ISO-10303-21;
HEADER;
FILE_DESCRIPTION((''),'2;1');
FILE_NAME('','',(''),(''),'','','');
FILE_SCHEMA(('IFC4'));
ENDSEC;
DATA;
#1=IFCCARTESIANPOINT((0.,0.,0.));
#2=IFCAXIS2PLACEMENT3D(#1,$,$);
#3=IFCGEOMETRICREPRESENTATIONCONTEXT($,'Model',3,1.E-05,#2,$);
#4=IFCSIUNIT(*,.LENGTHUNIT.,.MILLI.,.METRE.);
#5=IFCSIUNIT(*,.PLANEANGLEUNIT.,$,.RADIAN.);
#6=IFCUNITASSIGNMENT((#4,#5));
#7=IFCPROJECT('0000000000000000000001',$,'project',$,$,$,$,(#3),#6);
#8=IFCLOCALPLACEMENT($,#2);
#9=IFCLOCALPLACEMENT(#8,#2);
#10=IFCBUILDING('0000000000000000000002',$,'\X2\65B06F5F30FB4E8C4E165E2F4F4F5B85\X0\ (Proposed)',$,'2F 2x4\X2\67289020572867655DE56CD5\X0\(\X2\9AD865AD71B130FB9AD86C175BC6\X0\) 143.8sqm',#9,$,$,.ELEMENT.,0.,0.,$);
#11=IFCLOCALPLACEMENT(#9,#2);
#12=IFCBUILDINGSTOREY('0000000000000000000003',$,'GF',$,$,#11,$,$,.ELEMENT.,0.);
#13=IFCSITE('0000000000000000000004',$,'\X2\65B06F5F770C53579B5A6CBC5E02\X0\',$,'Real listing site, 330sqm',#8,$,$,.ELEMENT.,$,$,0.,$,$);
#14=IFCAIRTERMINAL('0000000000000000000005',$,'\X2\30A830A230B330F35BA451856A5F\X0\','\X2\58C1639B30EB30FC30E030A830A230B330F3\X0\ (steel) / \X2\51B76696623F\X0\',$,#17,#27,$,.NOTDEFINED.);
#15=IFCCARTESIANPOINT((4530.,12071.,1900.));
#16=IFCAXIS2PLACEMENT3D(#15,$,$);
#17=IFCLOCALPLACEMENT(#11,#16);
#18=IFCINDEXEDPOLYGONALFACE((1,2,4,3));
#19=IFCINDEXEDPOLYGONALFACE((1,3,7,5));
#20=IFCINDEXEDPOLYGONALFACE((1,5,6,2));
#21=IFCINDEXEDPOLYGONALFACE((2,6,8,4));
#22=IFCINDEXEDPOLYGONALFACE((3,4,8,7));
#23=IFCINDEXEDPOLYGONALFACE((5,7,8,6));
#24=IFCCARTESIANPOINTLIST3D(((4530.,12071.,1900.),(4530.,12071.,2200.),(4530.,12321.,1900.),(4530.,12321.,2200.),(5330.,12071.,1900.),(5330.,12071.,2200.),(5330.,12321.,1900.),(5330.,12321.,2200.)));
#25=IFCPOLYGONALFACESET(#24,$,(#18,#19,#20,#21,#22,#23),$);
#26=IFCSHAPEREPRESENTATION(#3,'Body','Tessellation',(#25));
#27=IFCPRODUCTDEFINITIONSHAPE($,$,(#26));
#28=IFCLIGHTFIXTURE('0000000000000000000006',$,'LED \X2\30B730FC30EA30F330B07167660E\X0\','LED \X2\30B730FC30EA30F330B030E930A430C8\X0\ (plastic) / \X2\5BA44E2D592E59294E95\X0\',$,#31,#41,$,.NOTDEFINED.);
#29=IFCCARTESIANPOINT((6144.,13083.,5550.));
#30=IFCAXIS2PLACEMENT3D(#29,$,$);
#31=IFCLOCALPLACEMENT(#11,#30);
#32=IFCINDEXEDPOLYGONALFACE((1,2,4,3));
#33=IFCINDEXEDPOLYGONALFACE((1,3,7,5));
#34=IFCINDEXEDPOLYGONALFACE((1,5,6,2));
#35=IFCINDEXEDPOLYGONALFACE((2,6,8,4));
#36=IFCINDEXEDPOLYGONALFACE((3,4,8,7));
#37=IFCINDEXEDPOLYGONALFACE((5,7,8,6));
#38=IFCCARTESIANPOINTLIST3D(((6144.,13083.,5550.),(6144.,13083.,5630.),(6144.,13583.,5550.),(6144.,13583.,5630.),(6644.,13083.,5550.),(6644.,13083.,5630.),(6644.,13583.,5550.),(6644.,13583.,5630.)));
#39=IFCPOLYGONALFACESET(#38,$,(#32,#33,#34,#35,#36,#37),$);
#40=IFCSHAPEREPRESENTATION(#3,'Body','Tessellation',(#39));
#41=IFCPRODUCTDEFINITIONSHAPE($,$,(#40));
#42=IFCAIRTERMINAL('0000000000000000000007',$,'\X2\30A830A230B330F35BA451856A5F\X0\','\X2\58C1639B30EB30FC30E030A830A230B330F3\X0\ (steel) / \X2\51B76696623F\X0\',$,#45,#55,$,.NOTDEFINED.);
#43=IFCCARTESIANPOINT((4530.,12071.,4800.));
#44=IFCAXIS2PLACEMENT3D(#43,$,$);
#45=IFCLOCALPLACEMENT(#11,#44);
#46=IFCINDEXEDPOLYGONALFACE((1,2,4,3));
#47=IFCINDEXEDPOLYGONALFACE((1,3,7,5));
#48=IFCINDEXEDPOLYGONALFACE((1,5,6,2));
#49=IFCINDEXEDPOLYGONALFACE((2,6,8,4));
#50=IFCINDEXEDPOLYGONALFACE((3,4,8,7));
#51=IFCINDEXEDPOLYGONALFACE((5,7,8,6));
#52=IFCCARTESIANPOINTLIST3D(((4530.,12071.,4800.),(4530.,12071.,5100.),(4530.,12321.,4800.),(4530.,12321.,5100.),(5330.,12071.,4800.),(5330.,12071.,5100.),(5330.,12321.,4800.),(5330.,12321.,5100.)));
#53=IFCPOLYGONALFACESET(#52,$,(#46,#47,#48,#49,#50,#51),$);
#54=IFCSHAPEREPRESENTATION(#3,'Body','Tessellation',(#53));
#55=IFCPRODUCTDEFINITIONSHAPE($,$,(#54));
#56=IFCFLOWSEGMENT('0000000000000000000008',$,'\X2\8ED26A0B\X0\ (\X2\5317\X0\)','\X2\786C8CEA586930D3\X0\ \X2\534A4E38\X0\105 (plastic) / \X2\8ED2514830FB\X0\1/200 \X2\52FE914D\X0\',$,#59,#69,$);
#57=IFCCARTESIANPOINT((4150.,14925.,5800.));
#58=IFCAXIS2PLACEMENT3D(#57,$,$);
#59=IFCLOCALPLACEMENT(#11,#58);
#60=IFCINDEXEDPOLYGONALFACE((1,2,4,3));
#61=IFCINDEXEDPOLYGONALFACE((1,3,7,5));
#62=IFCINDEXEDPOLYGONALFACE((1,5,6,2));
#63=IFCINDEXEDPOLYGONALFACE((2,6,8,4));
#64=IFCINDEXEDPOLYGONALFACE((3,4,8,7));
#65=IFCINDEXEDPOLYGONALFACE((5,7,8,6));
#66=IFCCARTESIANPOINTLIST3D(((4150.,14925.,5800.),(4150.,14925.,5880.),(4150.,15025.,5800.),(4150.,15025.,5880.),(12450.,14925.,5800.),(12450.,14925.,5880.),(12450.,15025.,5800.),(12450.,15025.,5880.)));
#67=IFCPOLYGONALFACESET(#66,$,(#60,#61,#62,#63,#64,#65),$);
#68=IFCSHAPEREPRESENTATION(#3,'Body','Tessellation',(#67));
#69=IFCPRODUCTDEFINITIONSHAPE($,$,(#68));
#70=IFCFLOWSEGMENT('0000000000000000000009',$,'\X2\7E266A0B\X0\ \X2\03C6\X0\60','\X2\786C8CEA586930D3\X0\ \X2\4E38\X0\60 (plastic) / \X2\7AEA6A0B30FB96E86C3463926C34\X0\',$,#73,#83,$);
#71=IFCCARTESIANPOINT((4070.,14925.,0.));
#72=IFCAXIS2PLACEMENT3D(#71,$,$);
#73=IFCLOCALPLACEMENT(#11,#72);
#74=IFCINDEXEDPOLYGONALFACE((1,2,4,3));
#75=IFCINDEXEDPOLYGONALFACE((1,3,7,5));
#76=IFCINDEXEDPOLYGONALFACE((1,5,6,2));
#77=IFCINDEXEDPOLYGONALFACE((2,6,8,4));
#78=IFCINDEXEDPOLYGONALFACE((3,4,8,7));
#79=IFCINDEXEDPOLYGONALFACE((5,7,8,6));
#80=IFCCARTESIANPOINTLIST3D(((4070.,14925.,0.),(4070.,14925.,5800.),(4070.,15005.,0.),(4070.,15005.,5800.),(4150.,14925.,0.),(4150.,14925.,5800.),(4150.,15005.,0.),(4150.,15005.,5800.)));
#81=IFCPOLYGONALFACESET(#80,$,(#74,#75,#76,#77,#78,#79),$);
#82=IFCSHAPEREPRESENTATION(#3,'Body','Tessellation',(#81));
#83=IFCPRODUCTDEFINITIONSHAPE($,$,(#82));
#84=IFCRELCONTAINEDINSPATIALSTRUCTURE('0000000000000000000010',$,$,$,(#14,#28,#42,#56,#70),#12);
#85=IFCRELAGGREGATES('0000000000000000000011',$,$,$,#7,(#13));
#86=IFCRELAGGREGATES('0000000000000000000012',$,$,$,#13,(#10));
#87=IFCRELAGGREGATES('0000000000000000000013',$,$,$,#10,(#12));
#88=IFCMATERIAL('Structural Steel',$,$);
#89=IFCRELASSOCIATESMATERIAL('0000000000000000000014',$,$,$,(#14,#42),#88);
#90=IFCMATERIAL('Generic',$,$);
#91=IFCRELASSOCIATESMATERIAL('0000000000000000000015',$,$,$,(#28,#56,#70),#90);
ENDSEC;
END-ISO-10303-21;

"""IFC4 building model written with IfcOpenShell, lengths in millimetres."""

from ifc_helpers import new_model, si_unit, frame, frame_2d, origin, place, context, project, spatial, rectangle, extrude, material, element, save


model = new_model("IFC4")

# Units and contexts
model_context = context("Model", 3, precision=1e-05, world=origin())
ifc_project = project(units=[si_unit("LENGTHUNIT", "METRE", prefix="MILLI"), si_unit("PLANEANGLEUNIT", "RADIAN")], contexts=[model_context])

# Site, building, storey
site_placement = place(None, origin())
site = spatial("IfcSite", under=ifc_project, at=site_placement, Name="新潟県南魚沼市", ObjectType="Real listing site, 330sqm", CompositionType="ELEMENT", RefElevation=0.0)
building_placement = place(site_placement, origin())
building = spatial("IfcBuilding", under=site, at=building_placement, Name="新潟・二世帯住宅 (Proposed)", ObjectType="2F 2x4木造在来工法(高断熱・高気密) 143.8sqm", CompositionType="ELEMENT", ElevationOfRefHeight=0.0, ElevationOfTerrain=0.0)
storey_placement = place(building_placement, origin())
storey = spatial("IfcBuildingStorey", under=building, at=storey_placement, Name="GF", CompositionType="ELEMENT", Elevation=0.0)

# Shared definitions
ifc_material_1 = material(Name="Generic")

# Shared definitions
ifc_material_2 = material(Name="Structural Steel")

# Air terminal
air_terminal_1_placement = place(storey_placement, frame((4530.0, 12071.0, 1900.0)))
element("IfcAirTerminal", 1, at=air_terminal_1_placement, inside=storey, material=ifc_material_2, Name="エアコン室内機", Description="壁掛ルームエアコン (steel) / 冷暖房", PredefinedType="NOTDEFINED", context=model_context, shape_type="SweptSolid", body=[
    extrude(rectangle(XDim=800.0, YDim=250.0, at=frame_2d((400.0, 125.0))), frame((4530.0, 12071.0, 1900.0)), (0.0, 0.0, 1.0), 300.0),
])

# Light fixture
light_fixture_placement = place(storey_placement, frame((6144.0, 13083.0, 5550.0)))
element("IfcLightFixture", 2, at=light_fixture_placement, inside=storey, material=ifc_material_1, Name="LED シーリング照明", Description="LED シーリングライト (plastic) / 室中央天井", PredefinedType="NOTDEFINED", context=model_context, shape_type="SweptSolid", body=[
    extrude(rectangle(XDim=500.0, YDim=500.0, at=frame_2d((250.0, 250.0))), frame((6144.0, 13083.0, 5550.0)), (0.0, 0.0, 1.0), 80.0),
])

# Air terminal
air_terminal_2_placement = place(storey_placement, frame((4530.0, 12071.0, 4800.0)))
element("IfcAirTerminal", 3, at=air_terminal_2_placement, inside=storey, material=ifc_material_2, Name="エアコン室内機", Description="壁掛ルームエアコン (steel) / 冷暖房", PredefinedType="NOTDEFINED", context=model_context, shape_type="SweptSolid", body=[
    extrude(rectangle(XDim=800.0, YDim=250.0, at=frame_2d((400.0, 125.0))), frame((4530.0, 12071.0, 4800.0)), (0.0, 0.0, 1.0), 300.0),
])

# Flow segments
flow_segment_1_placement = place(storey_placement, frame((4150.0, 14925.0, 5800.0)))
element("IfcFlowSegment", 4, at=flow_segment_1_placement, inside=storey, material=ifc_material_1, Name="軒樋 (北)", Description="硬質塩ビ 半丸105 (plastic) / 軒先・1/200 勾配", context=model_context, shape_type="SweptSolid", body=[
    extrude(rectangle(XDim=8300.0, YDim=100.0, at=frame_2d((4150.0, 50.0))), frame((4150.0, 14925.0, 5800.0)), (0.0, 0.0, 1.0), 80.0),
])
flow_segment_2_placement = place(storey_placement, frame((4070.0, 14925.0, 0.0)))
element("IfcFlowSegment", 5, at=flow_segment_2_placement, inside=storey, material=ifc_material_1, Name="縦樋 φ60", Description="硬質塩ビ 丸60 (plastic) / 竪樋・雨水排水", context=model_context, shape_type="SweptSolid", body=[
    extrude(rectangle(XDim=80.0, YDim=80.0, at=frame_2d((40.0, 40.0))), frame((4070.0, 14925.0, 0.0)), (0.0, 0.0, 1.0), 5800.0),
])

save(model, "model.ifc")
